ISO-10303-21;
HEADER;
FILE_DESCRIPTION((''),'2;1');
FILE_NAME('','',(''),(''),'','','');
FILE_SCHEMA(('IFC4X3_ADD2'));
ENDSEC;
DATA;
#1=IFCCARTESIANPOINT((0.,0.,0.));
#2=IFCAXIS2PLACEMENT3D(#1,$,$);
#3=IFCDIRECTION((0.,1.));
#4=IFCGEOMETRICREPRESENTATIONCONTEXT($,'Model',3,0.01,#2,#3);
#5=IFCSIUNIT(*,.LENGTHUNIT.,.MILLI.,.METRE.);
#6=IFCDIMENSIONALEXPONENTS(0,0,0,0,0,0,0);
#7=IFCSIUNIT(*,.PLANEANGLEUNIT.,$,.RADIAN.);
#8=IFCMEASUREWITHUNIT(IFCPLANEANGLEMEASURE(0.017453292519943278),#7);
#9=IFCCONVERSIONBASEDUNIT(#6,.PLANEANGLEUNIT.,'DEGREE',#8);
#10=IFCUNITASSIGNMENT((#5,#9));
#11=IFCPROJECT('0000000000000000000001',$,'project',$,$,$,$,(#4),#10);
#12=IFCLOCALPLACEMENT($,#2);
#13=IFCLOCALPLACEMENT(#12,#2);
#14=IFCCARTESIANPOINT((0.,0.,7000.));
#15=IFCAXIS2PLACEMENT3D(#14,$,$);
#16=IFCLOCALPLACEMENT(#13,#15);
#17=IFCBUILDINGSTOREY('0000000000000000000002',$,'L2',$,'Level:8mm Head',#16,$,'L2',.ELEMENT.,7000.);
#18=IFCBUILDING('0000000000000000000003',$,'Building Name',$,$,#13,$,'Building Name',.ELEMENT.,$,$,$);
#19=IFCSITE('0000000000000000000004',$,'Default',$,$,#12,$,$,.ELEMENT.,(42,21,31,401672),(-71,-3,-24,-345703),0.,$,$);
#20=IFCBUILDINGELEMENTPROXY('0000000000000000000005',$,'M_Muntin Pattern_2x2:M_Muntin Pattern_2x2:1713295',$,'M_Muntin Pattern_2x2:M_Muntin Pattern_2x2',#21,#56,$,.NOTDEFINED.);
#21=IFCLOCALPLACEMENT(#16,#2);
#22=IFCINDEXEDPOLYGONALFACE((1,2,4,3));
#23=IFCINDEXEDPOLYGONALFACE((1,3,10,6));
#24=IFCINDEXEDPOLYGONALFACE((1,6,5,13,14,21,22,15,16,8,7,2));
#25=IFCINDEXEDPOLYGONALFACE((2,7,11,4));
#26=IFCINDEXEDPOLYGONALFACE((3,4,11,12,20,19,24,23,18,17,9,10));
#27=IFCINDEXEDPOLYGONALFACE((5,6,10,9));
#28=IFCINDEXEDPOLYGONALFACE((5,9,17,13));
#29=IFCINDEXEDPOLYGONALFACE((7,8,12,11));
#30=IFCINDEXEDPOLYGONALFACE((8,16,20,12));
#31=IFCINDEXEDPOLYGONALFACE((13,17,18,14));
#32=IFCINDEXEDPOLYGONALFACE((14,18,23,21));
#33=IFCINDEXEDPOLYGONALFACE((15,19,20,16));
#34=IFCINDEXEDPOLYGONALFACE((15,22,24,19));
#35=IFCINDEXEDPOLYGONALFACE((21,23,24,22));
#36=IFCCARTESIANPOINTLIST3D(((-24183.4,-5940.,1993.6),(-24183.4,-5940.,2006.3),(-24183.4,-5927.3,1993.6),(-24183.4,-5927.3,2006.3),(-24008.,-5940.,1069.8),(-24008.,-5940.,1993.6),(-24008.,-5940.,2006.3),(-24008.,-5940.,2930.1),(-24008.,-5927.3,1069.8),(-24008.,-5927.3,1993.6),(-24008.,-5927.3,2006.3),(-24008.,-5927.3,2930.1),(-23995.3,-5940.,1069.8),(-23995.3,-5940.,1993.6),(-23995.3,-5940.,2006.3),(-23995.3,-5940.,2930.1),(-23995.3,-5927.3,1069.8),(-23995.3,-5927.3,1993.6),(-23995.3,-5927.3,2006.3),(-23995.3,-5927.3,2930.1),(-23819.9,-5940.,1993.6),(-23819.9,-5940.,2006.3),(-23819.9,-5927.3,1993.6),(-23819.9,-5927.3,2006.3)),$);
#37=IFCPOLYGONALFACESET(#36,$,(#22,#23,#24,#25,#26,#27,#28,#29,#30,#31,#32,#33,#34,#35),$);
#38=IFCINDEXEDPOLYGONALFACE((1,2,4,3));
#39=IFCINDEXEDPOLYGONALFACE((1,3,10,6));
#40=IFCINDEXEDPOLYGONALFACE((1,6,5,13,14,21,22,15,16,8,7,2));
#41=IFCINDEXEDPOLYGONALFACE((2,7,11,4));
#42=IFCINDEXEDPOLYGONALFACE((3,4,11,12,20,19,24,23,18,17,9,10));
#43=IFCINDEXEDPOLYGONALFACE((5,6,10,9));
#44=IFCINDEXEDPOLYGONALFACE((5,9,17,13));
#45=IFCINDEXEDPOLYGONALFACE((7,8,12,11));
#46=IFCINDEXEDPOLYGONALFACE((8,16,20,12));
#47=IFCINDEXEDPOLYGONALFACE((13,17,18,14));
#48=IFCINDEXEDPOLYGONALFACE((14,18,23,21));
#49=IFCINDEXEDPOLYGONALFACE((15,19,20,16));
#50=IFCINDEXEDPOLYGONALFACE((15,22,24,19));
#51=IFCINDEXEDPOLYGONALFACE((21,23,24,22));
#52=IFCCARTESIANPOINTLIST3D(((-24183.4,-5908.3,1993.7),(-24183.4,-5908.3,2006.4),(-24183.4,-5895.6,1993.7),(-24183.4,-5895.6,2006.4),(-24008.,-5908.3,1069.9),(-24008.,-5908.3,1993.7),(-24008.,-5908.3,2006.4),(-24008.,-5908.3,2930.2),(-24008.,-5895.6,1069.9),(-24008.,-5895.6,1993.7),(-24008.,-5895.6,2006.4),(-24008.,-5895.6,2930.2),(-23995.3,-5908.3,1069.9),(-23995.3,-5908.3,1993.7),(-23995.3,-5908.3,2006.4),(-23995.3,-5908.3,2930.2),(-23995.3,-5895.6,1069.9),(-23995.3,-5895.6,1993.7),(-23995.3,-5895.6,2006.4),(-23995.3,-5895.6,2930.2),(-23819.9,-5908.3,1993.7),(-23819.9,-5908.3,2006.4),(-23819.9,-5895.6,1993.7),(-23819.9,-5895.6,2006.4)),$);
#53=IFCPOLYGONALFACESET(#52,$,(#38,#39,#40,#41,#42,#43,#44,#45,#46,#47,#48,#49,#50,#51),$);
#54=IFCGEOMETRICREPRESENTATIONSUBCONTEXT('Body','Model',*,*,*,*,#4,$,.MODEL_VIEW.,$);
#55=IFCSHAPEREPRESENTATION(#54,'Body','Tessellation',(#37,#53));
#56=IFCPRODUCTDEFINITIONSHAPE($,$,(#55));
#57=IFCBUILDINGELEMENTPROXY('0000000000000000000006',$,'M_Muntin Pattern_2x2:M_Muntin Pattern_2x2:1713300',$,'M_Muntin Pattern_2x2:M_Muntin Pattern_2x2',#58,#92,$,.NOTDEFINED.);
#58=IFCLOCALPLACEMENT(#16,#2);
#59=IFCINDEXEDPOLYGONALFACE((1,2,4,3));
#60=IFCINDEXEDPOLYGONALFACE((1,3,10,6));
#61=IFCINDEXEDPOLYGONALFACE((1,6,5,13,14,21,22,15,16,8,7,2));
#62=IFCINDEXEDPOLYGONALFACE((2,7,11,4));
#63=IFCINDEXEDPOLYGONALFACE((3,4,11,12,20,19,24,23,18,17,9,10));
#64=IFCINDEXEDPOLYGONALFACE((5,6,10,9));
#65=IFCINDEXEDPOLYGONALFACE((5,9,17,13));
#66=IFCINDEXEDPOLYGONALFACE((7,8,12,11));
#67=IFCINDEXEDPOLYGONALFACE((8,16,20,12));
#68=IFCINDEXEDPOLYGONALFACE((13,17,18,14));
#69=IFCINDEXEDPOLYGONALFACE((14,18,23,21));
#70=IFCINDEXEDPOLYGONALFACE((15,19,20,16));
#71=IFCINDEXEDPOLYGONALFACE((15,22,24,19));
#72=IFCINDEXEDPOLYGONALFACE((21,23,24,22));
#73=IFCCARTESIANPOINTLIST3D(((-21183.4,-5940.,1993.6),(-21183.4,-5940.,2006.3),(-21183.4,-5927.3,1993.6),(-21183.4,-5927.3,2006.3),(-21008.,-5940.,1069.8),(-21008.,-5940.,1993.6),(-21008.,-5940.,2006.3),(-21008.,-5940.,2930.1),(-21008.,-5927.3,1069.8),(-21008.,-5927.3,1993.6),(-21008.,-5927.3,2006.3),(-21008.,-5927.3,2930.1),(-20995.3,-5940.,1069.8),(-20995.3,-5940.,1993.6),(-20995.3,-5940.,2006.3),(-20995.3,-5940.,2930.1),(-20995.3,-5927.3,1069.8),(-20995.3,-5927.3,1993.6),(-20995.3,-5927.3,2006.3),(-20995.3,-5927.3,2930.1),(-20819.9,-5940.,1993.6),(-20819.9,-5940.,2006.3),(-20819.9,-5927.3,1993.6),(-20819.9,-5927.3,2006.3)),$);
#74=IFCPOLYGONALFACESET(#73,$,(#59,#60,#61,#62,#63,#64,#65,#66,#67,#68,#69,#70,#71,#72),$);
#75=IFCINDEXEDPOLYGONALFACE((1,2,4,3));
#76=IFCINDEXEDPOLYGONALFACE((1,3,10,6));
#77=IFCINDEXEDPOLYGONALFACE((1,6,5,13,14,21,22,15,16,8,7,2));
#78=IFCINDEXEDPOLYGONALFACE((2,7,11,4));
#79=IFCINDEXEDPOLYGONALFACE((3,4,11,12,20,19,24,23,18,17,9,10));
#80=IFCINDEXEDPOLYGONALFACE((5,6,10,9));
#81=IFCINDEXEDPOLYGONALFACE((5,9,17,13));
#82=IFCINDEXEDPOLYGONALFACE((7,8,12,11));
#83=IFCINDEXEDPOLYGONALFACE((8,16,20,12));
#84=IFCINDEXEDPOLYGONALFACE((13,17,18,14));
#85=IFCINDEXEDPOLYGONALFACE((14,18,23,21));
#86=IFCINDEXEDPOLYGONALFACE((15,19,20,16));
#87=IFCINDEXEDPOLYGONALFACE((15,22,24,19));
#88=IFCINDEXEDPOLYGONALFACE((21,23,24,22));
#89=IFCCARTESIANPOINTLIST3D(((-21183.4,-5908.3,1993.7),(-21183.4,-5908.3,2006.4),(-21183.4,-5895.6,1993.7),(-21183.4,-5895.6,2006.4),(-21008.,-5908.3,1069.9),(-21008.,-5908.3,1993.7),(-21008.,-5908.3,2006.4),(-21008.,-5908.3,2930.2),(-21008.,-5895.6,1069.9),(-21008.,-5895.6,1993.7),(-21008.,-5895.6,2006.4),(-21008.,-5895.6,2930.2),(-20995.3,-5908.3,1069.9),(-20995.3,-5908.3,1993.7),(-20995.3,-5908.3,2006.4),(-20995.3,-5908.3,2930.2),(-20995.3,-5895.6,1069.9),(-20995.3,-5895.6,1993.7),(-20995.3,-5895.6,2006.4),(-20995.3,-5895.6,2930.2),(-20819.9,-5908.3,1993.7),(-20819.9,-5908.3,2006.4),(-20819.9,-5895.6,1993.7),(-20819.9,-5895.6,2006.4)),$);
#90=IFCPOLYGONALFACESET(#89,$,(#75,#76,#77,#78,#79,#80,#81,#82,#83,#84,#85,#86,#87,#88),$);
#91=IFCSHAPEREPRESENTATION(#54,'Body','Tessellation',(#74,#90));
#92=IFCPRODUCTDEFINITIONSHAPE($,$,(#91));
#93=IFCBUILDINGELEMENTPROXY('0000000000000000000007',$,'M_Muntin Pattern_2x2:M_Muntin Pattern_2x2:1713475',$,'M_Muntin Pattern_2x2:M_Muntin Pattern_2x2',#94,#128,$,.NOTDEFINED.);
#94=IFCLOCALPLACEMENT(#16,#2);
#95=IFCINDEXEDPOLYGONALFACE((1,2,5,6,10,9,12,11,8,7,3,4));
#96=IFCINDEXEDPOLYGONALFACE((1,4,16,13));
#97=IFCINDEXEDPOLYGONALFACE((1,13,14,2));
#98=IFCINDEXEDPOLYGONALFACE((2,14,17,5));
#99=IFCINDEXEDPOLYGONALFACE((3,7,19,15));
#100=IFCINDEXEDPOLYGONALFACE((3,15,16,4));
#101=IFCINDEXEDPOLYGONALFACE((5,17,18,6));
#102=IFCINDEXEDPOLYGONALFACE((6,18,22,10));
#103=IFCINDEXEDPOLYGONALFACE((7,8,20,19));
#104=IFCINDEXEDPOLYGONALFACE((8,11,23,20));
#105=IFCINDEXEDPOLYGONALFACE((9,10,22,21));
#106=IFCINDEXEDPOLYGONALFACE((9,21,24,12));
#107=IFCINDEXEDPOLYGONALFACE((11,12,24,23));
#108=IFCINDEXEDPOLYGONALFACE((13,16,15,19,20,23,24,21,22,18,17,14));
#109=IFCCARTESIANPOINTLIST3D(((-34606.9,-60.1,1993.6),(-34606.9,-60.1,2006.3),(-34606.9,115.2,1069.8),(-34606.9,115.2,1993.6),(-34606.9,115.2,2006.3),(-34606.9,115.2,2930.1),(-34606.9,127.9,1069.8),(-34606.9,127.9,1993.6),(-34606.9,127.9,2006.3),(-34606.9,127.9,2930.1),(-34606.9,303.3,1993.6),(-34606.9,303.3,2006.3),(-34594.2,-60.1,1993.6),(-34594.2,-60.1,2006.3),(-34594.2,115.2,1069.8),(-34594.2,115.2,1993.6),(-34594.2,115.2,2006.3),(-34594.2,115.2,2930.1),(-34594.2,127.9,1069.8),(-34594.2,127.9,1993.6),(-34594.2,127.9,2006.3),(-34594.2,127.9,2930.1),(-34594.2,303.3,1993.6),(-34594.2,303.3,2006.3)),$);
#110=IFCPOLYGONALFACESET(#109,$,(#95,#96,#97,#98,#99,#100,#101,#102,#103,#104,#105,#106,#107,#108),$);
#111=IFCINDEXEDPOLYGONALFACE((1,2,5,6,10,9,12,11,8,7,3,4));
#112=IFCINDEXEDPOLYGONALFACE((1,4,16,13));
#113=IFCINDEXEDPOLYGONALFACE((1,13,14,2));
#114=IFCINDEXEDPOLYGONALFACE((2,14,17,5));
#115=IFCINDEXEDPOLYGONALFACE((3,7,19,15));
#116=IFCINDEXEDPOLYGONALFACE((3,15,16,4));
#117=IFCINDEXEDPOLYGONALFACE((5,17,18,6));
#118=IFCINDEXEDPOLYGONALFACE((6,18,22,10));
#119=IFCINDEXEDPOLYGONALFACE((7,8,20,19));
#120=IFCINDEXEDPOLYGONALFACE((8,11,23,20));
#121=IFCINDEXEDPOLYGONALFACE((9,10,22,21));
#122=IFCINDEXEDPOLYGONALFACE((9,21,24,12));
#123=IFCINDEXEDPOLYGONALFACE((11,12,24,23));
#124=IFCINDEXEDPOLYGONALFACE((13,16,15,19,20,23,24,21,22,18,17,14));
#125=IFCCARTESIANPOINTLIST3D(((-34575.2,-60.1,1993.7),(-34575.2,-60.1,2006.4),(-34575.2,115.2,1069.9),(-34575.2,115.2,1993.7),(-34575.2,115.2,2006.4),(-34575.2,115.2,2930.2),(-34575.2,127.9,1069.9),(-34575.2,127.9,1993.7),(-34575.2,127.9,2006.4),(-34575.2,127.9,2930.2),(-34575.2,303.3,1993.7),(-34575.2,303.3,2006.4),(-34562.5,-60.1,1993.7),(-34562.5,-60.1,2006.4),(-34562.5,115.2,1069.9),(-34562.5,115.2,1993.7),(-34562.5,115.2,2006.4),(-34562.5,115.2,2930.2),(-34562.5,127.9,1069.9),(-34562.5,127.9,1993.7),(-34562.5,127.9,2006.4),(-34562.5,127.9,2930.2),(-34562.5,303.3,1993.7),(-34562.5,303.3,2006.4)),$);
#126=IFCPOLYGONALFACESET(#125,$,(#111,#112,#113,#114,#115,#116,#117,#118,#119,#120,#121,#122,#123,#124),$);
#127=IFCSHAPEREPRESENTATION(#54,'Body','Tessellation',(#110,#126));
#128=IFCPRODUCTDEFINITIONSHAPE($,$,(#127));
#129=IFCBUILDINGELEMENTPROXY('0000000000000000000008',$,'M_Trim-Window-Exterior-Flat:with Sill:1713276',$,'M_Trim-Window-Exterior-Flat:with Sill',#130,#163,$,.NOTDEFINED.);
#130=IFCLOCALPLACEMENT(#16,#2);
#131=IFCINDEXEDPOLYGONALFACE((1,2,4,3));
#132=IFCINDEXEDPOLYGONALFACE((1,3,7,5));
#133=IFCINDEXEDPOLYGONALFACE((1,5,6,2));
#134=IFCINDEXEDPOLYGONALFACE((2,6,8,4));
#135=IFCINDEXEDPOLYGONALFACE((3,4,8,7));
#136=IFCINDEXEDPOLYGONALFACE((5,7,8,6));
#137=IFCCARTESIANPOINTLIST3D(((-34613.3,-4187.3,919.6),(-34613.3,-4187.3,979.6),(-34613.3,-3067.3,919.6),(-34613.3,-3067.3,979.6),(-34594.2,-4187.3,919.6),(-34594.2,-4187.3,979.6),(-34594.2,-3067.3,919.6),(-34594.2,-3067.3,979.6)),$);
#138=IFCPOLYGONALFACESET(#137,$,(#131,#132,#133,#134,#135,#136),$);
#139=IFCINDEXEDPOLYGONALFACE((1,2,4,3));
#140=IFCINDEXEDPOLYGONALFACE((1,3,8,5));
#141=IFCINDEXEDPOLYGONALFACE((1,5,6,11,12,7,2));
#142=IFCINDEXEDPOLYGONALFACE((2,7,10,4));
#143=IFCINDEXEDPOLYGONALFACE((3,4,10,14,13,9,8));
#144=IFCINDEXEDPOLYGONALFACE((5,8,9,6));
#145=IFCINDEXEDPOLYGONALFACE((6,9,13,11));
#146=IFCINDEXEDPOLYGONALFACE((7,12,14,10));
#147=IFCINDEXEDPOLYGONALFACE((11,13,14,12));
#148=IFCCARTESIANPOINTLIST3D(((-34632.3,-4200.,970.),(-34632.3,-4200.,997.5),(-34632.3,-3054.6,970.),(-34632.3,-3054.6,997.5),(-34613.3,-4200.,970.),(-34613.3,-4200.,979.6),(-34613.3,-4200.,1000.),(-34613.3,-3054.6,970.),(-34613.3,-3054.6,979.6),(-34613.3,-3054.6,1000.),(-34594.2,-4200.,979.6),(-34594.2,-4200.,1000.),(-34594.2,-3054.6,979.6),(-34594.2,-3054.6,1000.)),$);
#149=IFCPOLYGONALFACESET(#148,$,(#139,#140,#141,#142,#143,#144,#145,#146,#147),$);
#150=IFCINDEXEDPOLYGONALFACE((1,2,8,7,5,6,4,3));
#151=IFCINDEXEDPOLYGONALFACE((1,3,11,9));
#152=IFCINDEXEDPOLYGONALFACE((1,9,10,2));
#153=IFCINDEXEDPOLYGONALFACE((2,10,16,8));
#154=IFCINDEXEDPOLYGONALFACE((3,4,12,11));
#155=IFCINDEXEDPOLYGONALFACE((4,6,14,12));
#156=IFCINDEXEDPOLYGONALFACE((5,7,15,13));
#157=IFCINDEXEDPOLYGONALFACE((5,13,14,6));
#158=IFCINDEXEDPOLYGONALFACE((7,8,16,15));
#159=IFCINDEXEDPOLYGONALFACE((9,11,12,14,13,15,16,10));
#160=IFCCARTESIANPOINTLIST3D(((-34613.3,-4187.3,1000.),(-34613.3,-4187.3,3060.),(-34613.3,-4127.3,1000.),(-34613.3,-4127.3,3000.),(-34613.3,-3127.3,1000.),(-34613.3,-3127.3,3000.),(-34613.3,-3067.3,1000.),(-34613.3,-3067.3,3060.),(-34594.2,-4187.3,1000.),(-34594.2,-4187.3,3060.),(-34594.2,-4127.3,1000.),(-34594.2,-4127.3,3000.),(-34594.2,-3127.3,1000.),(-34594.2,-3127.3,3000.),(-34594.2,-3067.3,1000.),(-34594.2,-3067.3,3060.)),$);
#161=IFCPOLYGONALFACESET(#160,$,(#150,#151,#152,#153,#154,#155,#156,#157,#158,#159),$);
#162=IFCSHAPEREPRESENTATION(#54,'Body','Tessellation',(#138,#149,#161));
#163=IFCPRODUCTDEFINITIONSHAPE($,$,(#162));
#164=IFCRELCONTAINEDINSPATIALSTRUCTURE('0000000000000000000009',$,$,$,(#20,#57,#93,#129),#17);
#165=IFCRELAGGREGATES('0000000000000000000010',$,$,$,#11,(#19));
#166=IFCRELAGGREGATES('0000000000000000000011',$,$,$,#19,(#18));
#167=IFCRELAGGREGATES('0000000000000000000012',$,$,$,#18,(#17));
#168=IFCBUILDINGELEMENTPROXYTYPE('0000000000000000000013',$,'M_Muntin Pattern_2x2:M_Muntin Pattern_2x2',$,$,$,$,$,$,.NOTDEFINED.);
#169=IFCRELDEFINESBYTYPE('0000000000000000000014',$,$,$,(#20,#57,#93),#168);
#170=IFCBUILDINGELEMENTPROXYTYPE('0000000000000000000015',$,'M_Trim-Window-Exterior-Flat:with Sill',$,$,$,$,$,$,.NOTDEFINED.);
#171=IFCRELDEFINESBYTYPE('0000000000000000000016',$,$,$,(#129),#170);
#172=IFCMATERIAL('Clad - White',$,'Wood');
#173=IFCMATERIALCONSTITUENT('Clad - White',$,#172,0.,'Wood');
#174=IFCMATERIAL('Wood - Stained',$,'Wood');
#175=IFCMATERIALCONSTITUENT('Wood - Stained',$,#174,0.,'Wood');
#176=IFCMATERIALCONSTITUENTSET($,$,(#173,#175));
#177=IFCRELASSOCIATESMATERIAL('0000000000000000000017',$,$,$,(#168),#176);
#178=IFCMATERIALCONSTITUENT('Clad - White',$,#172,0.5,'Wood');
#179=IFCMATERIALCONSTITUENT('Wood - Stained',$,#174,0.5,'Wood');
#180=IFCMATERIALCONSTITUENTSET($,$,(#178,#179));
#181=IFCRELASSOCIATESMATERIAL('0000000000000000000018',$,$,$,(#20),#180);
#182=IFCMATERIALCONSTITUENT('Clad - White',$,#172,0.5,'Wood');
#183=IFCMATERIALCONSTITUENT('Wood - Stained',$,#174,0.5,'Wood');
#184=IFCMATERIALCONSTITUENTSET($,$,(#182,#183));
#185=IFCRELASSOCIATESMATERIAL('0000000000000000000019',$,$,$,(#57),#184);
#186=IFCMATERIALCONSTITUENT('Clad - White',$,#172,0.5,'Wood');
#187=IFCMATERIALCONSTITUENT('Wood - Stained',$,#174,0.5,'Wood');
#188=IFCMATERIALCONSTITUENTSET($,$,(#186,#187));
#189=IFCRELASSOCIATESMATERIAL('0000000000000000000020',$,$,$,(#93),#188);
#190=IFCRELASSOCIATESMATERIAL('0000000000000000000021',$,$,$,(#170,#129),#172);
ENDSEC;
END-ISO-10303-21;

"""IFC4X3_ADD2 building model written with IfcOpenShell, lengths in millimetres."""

from ifc_helpers import new_model, entity, si_unit, converted_unit, direction, frame, frame_2d, origin, place, context, subcontext, project, spatial, polyline, rectangle, outline, extrude, source, transform, mapped, material, constituent, constituent_set, type_object, type_shapes, element, save


model = new_model("IFC4X3_ADD2")

# Units and contexts
model_context = context("Model", 3, precision=0.01, world=origin(), true_north=direction((0.0, 1.0)))
body_context = subcontext(model_context, "Body", "Model", "MODEL_VIEW")
ifc_project = project(units=[si_unit("LENGTHUNIT", "METRE", prefix="MILLI"), converted_unit("PLANEANGLEUNIT", "DEGREE", entity("IfcPlaneAngleMeasure", 0.017453292519943278), si_unit("PLANEANGLEUNIT", "RADIAN"), dimensions=[0, 0, 0, 0, 0, 0, 0])], contexts=[model_context])

# Site, building, storey
site_placement = place(None, origin())
site = spatial("IfcSite", under=ifc_project, at=site_placement, Name="Default", CompositionType="ELEMENT", RefLatitude=(42, 21, 31, 401672), RefLongitude=(-71, -3, -24, -345703), RefElevation=0.0)
building_placement = place(site_placement, origin())
building = spatial("IfcBuilding", under=site, at=building_placement, Name="Building Name", LongName="Building Name", CompositionType="ELEMENT")
storey_placement = place(building_placement, frame((0.0, 0.0, 7000.0)))
storey = spatial("IfcBuildingStorey", under=building, at=storey_placement, Name="L2", ObjectType="Level:8mm Head", LongName="L2", CompositionType="ELEMENT", Elevation=7000.0)

# Building element proxies
ifc_material_1 = material(Name="Clad - White", Category="Wood")
ifc_material_2 = material(Name="Wood - Stained", Category="Wood")
ifc_constituent_1 = constituent(ifc_material_1, Name="Clad - White", Category="Wood", fraction=0.0)
ifc_constituent_2 = constituent(ifc_material_2, Name="Wood - Stained", Category="Wood", fraction=0.0)
ifc_constituent_set_1 = constituent_set(constituents=[ifc_constituent_1, ifc_constituent_2])
building_element_proxy_type_1 = type_object("IfcBuildingElementProxyType", Name="M_Muntin Pattern_2x2:M_Muntin Pattern_2x2", PredefinedType="NOTDEFINED", material=ifc_constituent_set_1)
shared_shape_1 = source(origin(), body_context, "Body", "SweptSolid", [
    extrude(outline(polyline([(6.4, -6.4), (930.1, -6.4), (930.1, 6.3), (6.4, 6.3), (6.4, 181.7), (-6.3, 181.7), (-6.3, 6.3), (-930.2, 6.3), (-930.2, -6.4), (-6.3, -6.4), (-6.3, -181.7), (6.4, -181.7), (6.4, -6.4)])), frame((0.0, -22.2, 930.1), z_axis=(0.0, 1.0, 0.0), x_axis=(0.0, 0.0, 1.0)), (0.0, 0.0, 1.0), 12.7),
    extrude(outline(polyline([(6.4, -6.4), (930.2, -6.4), (930.2, 6.3), (6.4, 6.3), (6.4, 181.7), (-6.3, 181.7), (-6.3, 6.3), (-930.2, 6.3), (-930.2, -6.4), (-6.3, -6.4), (-6.3, -181.7), (6.4, -181.7), (6.4, -6.4)])), frame((0.0, 9.5, 930.2), z_axis=(0.0, 1.0, 0.0), x_axis=(0.0, 0.0, 1.0)), (0.0, 0.0, 1.0), 12.7),
])
type_shapes(building_element_proxy_type_1, [shared_shape_1])
ifc_constituent_3 = constituent(ifc_material_1, Name="Clad - White", Category="Wood", fraction=0.5)
ifc_constituent_4 = constituent(ifc_material_2, Name="Wood - Stained", Category="Wood", fraction=0.5)
ifc_constituent_set_2 = constituent_set(constituents=[ifc_constituent_3, ifc_constituent_4])
proxy_1_placement = place(storey_placement, frame((-24001.6, -5917.8, 1069.9)))
element("IfcBuildingElementProxy", 1, at=proxy_1_placement, inside=storey, type_object=building_element_proxy_type_1, material=ifc_constituent_set_2, Name="M_Muntin Pattern_2x2:M_Muntin Pattern_2x2:1713295", ObjectType="M_Muntin Pattern_2x2:M_Muntin Pattern_2x2", PredefinedType="NOTDEFINED", context=body_context, shape_type="MappedRepresentation", body=[
    mapped(shared_shape_1, transform((0.0, 0.0, 0.0), scale=1.0)),
])
ifc_constituent_5 = constituent(ifc_material_1, Name="Clad - White", Category="Wood", fraction=0.5)
ifc_constituent_6 = constituent(ifc_material_2, Name="Wood - Stained", Category="Wood", fraction=0.5)
ifc_constituent_set_3 = constituent_set(constituents=[ifc_constituent_5, ifc_constituent_6])
proxy_2_placement = place(storey_placement, frame((-21001.6, -5917.8, 1069.9)))
element("IfcBuildingElementProxy", 2, at=proxy_2_placement, inside=storey, type_object=building_element_proxy_type_1, material=ifc_constituent_set_3, Name="M_Muntin Pattern_2x2:M_Muntin Pattern_2x2:1713300", ObjectType="M_Muntin Pattern_2x2:M_Muntin Pattern_2x2", PredefinedType="NOTDEFINED", context=body_context, shape_type="MappedRepresentation", body=[
    mapped(shared_shape_1, transform((0.0, 0.0, 0.0), scale=1.0)),
])
ifc_constituent_7 = constituent(ifc_material_1, Name="Clad - White", Category="Wood", fraction=0.5)
ifc_constituent_8 = constituent(ifc_material_2, Name="Wood - Stained", Category="Wood", fraction=0.5)
ifc_constituent_set_4 = constituent_set(constituents=[ifc_constituent_7, ifc_constituent_8])
proxy_3_placement = place(storey_placement, frame((-34584.7, 121.6, 1069.9), z_axis=(0.0, 0.0, 1.0), x_axis=(0.0, -1.0, 0.0)))
element("IfcBuildingElementProxy", 3, at=proxy_3_placement, inside=storey, type_object=building_element_proxy_type_1, material=ifc_constituent_set_4, Name="M_Muntin Pattern_2x2:M_Muntin Pattern_2x2:1713475", ObjectType="M_Muntin Pattern_2x2:M_Muntin Pattern_2x2", PredefinedType="NOTDEFINED", context=body_context, shape_type="MappedRepresentation", body=[
    mapped(shared_shape_1, transform((0.0, 0.0, 0.0), scale=1.0)),
])
building_element_proxy_type_2 = type_object("IfcBuildingElementProxyType", Name="M_Trim-Window-Exterior-Flat:with Sill", PredefinedType="NOTDEFINED", material=ifc_material_1)
shared_shape_2 = source(origin(), body_context, "Body", "SweptSolid", [
    extrude(rectangle(XDim=1120.0, YDim=60.0, at=frame_2d((0.0, 0.0), x_axis=(1.0, 0.0))), frame((0.0, -2050.4, 0.0), z_axis=(0.0, 0.0, 1.0), x_axis=(-1.0, 0.0, 0.0)), (0.0, 0.0, 1.0), 19.0),
    extrude(outline(polyline([(-19.0, -15.2), (0.0, -15.2), (0.0, -5.7), (19.0, -5.7), (19.0, 14.8), (0.0, 14.8), (-19.0, 12.3), (-19.0, -15.2)])), frame((-572.7, -2014.8, 19.0), z_axis=(1.0, 0.0, 0.0), x_axis=(0.0, 0.0, -1.0)), (0.0, 0.0, 1.0), 1145.4),
    extrude(outline(polyline([(-1045.0, -560.0), (1015.0, -560.0), (1015.0, -500.0), (-985.0, -500.0), (-985.0, 500.0), (1015.0, 500.0), (1015.0, 560.0), (-1045.0, 560.0), (-1045.0, -560.0)])), frame((0.0, -985.0, 0.0), z_axis=(0.0, 0.0, 1.0), x_axis=(0.0, -1.0, 0.0)), (0.0, 0.0, 1.0), 19.0),
])
type_shapes(building_element_proxy_type_2, [shared_shape_2])
for number, where, z_axis, x_axis, name in (
    (4, (-34594.2, -3627.3, 3000.0), (-1.0, 0.0, 0.0), (0.0, -1.0, 0.0), "M_Trim-Window-Exterior-Flat:with Sill:1713276"),
):
    element("IfcBuildingElementProxy", number, at=place(storey_placement, frame(where, z_axis=z_axis, x_axis=x_axis)), inside=storey, type_object=building_element_proxy_type_2, material=ifc_material_1, Name=name, ObjectType="M_Trim-Window-Exterior-Flat:with Sill", PredefinedType="NOTDEFINED", context=body_context, shape_type="MappedRepresentation", body=[
        mapped(shared_shape_2, transform((0.0, 0.0, 0.0), scale=1.0)),
    ])

save(model, "model.ifc")
